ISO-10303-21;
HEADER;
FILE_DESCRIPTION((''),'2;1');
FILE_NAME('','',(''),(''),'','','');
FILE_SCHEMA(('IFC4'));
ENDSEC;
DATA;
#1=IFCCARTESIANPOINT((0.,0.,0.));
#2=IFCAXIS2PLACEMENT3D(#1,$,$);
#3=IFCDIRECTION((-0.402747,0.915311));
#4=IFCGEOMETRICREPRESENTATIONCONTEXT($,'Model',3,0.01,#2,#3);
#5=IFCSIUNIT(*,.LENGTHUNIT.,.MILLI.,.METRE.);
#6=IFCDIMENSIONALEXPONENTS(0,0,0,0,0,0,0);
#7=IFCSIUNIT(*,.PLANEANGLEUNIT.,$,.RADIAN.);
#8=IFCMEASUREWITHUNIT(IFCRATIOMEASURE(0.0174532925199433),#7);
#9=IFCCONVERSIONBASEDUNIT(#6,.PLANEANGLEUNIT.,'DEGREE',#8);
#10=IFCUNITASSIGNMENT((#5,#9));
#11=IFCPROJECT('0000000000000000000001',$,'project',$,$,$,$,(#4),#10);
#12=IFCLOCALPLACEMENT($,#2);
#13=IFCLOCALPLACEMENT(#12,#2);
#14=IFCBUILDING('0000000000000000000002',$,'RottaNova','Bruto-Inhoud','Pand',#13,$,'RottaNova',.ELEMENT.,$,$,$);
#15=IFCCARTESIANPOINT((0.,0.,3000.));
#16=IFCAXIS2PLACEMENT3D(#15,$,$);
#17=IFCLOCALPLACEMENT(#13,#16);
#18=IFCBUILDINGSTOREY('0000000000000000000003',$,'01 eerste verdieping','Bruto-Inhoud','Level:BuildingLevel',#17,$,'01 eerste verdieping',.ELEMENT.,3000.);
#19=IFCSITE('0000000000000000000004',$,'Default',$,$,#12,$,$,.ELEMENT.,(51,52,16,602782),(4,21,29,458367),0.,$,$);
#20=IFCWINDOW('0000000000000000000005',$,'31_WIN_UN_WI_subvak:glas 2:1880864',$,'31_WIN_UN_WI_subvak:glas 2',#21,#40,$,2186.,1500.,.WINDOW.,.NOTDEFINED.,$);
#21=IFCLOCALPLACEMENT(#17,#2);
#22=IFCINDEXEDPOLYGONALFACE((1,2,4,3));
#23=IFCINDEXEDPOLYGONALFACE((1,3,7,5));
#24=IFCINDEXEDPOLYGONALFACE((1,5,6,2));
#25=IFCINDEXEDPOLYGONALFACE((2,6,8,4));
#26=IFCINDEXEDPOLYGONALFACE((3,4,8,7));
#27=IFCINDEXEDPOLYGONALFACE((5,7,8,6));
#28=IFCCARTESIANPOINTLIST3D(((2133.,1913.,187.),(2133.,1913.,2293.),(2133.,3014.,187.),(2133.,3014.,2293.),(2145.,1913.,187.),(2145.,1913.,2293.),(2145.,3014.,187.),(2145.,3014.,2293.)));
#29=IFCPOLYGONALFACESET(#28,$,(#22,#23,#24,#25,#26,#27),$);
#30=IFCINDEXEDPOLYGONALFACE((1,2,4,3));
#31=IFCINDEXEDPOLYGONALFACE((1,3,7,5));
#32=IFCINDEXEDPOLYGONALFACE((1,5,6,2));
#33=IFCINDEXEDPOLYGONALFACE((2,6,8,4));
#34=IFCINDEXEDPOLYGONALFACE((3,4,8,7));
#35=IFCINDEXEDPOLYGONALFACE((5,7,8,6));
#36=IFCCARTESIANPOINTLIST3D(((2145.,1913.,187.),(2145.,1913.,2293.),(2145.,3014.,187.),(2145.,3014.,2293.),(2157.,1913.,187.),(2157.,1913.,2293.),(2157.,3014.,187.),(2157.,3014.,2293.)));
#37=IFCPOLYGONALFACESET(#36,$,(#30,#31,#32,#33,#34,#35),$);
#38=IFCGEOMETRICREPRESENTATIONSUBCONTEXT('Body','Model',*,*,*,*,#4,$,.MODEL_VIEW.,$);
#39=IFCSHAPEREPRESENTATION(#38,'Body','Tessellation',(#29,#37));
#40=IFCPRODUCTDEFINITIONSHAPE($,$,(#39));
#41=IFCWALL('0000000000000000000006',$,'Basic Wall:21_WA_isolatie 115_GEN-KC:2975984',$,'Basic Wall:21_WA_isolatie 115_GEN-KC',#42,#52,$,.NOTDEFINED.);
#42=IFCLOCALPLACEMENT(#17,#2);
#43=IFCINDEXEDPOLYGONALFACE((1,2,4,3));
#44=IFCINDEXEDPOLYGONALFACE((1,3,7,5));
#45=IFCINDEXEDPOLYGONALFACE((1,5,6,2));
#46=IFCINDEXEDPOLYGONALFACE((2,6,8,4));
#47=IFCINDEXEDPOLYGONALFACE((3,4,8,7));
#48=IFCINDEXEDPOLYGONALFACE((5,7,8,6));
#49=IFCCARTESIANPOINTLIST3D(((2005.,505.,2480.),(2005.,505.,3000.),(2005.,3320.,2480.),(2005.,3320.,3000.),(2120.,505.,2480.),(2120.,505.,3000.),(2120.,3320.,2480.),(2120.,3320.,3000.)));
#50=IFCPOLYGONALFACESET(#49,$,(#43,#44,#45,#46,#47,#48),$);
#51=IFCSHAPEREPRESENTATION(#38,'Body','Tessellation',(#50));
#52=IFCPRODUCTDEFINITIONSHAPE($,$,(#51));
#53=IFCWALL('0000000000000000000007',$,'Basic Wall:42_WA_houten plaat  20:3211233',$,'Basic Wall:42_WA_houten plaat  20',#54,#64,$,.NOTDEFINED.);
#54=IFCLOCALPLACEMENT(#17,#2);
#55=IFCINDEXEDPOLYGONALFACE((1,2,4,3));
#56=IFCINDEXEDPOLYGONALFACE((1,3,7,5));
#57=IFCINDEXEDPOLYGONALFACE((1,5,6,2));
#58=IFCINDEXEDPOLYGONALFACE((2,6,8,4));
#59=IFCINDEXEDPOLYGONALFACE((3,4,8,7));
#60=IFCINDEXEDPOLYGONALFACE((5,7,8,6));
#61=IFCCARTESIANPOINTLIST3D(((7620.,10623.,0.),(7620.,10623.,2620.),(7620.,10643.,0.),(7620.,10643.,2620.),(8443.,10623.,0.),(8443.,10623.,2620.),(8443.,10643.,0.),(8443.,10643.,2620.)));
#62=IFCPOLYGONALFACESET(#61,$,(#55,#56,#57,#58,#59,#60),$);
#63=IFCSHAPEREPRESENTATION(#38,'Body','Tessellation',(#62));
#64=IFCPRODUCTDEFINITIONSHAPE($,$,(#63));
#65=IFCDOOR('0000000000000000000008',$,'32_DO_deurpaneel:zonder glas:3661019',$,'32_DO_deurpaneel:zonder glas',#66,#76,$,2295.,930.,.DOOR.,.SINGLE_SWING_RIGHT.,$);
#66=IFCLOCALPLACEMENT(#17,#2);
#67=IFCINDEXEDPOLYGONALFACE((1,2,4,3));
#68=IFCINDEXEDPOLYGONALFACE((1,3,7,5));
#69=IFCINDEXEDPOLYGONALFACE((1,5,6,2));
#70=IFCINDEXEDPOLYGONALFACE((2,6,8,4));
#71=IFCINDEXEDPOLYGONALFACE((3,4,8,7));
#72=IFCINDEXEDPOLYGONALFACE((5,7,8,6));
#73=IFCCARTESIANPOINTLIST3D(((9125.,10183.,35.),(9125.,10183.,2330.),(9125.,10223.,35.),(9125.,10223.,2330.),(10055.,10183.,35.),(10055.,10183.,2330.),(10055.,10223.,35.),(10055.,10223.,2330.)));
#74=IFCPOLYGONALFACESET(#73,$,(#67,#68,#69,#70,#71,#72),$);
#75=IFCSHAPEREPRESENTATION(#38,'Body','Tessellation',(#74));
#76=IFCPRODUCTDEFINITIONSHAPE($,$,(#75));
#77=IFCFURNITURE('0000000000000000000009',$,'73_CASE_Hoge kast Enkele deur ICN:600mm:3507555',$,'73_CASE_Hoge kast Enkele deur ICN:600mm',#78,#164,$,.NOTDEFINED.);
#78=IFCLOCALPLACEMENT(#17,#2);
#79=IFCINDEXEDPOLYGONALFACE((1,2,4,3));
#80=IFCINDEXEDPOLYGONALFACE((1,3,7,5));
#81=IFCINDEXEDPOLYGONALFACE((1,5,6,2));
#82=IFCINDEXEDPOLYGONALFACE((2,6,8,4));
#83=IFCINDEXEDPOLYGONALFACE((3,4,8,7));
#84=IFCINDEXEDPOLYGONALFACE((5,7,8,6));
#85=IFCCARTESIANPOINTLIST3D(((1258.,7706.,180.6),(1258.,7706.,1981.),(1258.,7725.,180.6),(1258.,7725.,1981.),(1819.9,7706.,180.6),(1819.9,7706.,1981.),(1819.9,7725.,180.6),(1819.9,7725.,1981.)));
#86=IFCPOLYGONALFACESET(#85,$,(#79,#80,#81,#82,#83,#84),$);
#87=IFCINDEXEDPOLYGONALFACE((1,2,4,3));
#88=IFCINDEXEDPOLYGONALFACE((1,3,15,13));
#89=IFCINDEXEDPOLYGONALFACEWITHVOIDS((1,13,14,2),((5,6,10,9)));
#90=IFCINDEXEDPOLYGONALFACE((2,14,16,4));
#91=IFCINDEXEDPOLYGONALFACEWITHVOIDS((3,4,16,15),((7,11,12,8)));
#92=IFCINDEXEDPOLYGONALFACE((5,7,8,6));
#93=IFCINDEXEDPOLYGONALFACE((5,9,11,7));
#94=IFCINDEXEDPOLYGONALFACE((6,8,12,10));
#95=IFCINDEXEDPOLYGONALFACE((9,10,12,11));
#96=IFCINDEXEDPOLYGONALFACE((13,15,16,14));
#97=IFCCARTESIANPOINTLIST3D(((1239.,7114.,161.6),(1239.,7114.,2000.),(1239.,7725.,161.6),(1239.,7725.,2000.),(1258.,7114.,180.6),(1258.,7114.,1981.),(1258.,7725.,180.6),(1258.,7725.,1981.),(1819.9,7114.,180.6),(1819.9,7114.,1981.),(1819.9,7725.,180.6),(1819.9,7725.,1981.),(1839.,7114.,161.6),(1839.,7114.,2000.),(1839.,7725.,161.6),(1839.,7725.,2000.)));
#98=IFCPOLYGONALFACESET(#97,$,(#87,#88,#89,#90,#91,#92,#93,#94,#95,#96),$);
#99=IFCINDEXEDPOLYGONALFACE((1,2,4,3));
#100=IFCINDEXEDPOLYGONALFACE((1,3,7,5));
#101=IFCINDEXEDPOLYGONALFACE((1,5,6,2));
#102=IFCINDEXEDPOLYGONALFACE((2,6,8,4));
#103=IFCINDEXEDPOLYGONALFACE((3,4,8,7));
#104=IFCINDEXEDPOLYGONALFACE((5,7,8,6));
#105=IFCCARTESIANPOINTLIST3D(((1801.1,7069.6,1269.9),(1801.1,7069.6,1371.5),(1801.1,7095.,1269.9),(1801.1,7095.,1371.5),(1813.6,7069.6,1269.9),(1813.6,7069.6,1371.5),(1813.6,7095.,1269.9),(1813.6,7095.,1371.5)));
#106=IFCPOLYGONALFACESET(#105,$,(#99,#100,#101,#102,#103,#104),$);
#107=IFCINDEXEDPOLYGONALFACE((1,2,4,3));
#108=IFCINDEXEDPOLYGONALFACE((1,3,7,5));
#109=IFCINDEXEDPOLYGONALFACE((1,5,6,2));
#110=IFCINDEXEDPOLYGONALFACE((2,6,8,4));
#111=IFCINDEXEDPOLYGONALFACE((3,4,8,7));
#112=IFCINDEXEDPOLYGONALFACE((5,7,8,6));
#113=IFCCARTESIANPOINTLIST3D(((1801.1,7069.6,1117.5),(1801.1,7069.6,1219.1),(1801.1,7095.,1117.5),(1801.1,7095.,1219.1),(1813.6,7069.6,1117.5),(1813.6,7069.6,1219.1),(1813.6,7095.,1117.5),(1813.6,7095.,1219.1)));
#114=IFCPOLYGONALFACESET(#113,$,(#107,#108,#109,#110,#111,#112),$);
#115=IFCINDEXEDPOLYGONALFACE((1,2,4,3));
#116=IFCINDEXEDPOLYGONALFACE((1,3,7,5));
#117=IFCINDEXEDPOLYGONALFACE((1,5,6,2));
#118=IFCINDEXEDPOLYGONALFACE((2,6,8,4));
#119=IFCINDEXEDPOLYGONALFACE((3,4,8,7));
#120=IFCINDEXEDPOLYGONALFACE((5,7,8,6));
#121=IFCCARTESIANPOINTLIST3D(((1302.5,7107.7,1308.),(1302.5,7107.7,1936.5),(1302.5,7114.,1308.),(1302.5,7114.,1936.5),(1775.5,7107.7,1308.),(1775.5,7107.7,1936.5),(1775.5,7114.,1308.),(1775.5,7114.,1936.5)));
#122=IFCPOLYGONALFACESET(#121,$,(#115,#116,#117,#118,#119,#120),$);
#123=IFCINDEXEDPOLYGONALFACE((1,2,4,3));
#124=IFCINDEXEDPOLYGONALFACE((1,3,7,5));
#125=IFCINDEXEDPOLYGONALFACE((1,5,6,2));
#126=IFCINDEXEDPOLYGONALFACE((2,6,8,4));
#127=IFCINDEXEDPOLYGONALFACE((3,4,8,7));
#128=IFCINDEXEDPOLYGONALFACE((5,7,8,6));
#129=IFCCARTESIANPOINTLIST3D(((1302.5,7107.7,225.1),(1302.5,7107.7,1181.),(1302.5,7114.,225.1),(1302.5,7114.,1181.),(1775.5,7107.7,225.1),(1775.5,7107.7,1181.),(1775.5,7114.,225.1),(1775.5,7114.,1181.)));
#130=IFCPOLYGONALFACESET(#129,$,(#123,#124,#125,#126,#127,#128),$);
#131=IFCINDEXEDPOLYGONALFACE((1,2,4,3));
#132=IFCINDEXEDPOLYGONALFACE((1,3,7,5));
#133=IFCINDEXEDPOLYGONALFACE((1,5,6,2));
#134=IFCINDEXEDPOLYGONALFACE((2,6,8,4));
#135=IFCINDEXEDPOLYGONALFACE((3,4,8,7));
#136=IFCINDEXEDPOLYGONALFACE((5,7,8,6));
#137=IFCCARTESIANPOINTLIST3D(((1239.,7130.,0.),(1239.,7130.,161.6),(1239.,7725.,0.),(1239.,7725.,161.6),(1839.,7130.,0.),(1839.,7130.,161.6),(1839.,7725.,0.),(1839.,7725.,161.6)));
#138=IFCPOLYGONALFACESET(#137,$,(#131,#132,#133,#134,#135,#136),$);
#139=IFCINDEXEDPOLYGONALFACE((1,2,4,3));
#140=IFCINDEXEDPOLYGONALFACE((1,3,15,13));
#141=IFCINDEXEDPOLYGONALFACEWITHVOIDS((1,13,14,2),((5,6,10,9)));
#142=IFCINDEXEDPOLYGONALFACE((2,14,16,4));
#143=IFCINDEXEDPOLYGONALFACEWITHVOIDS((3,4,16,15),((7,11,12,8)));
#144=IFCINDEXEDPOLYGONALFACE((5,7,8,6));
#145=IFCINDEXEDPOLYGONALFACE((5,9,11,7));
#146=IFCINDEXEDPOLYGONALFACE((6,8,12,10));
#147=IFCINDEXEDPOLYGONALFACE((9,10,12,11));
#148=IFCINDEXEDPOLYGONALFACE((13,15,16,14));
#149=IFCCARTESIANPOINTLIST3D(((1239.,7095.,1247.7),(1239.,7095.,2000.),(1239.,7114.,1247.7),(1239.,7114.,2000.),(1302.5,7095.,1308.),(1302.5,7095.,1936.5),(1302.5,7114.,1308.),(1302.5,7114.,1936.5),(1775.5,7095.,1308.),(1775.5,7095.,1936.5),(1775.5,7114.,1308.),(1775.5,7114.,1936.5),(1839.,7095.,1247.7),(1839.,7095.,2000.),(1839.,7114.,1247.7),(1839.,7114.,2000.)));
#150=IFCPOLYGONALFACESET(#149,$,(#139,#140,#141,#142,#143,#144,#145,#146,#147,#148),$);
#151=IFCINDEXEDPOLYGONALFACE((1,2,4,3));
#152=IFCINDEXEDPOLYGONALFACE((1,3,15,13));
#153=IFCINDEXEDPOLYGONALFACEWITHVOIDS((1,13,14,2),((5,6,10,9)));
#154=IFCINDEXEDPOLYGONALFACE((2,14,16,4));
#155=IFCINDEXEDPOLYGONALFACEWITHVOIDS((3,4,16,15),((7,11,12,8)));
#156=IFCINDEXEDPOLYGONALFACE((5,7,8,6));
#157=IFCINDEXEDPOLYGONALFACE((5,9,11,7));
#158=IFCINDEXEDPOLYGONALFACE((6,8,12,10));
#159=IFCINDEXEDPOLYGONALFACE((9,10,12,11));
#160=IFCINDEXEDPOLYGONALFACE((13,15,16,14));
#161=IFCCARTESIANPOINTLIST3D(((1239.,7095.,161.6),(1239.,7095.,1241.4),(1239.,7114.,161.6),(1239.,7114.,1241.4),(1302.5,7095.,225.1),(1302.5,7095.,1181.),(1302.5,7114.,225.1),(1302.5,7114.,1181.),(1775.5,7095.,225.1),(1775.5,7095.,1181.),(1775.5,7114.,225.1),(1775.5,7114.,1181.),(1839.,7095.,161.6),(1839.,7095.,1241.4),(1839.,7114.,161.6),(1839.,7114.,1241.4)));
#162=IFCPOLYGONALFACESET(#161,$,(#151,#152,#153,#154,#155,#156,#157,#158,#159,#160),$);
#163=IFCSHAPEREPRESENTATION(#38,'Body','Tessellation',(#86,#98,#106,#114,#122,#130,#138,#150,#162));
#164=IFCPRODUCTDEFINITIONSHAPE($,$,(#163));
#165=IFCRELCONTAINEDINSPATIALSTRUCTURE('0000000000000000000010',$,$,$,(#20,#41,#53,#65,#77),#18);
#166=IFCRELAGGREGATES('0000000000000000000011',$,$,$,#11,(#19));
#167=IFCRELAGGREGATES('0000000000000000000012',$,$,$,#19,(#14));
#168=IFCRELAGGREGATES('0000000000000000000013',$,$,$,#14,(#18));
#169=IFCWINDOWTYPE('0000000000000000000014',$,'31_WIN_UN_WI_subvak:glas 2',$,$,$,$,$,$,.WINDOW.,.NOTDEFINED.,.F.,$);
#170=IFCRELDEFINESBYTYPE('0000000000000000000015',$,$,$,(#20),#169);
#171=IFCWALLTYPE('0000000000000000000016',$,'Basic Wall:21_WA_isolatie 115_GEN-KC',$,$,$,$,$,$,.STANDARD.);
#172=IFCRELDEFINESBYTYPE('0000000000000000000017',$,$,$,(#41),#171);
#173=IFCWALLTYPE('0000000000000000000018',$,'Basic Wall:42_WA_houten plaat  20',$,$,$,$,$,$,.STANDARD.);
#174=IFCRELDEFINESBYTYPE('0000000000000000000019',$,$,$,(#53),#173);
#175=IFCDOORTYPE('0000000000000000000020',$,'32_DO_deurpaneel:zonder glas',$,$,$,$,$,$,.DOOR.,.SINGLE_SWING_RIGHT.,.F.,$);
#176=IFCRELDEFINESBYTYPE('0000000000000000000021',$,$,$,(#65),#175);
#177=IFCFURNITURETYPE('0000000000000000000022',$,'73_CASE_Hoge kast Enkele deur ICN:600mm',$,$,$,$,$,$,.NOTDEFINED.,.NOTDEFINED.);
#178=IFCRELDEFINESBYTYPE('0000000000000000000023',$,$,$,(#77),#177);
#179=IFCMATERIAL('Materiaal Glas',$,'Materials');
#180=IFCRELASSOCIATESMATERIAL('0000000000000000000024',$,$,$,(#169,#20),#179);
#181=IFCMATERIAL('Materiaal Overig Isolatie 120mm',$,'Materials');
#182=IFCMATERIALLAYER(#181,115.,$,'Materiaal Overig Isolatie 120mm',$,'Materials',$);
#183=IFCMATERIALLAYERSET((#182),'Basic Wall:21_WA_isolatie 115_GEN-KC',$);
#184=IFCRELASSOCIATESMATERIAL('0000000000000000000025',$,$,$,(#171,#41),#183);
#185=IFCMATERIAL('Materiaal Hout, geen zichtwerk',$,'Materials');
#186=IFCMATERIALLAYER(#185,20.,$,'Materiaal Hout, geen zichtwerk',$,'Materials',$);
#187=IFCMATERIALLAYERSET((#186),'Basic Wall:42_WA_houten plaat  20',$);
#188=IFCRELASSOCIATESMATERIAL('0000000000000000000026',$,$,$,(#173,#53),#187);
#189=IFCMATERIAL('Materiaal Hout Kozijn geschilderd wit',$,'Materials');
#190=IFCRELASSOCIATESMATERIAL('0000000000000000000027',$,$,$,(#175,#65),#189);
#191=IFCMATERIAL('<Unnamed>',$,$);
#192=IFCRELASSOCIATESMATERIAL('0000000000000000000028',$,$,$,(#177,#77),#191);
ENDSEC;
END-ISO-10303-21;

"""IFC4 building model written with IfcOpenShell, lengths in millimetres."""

from ifc_helpers import new_model, entity, si_unit, converted_unit, direction, frame, frame_2d, origin, origin_2d_with_axis, place, context, subcontext, project, spatial, polyline, rectangle, outline, extrude, source, transform, mapped, material, layer, layer_set, type_object, type_shapes, element, save


model = new_model("IFC4")

# Units and contexts
model_context = context("Model", 3, precision=0.01, world=origin(), true_north=direction((-0.402747, 0.915311)))
body_context = subcontext(model_context, "Body", "Model", "MODEL_VIEW")
ifc_project = project(units=[si_unit("LENGTHUNIT", "METRE", prefix="MILLI"), converted_unit("PLANEANGLEUNIT", "DEGREE", entity("IfcRatioMeasure", 0.0174532925199433), si_unit("PLANEANGLEUNIT", "RADIAN"), dimensions=[0, 0, 0, 0, 0, 0, 0])], contexts=[model_context])

# Site, building, storey
site_placement = place(None, origin())
site = spatial("IfcSite", under=ifc_project, at=site_placement, Name="Default", CompositionType="ELEMENT", RefLatitude=(51, 52, 16, 602782), RefLongitude=(4, 21, 29, 458367), RefElevation=0.0)
building_placement = place(site_placement, origin())
building = spatial("IfcBuilding", under=site, at=building_placement, Name="RottaNova", Description="Bruto-Inhoud", ObjectType="Pand", LongName="RottaNova", CompositionType="ELEMENT")
storey_placement = place(building_placement, frame((0.0, 0.0, 3000.0)))
storey = spatial("IfcBuildingStorey", under=building, at=storey_placement, Name="01 eerste verdieping", Description="Bruto-Inhoud", ObjectType="Level:BuildingLevel", LongName="01 eerste verdieping", CompositionType="ELEMENT", Elevation=3000.0)

# Shared definitions
ifc_material_1 = material(Name="Materiaal Glas", Category="Materials")

# Window
window_type = type_object("IfcWindowType", Name="31_WIN_UN_WI_subvak:glas 2", ParameterTakesPrecedence=False, PartitioningType="NOTDEFINED", PredefinedType="WINDOW", material=ifc_material_1)
shared_shape_1 = source(origin(), body_context, "Body", "SweptSolid", [
    extrude(rectangle(XDim=12.0, YDim=1101.0, at=frame_2d((0.0, 0.0), x_axis=(1.0, 0.0))), frame((0.0, 6.0, 0.0), z_axis=(0.0, 0.0, 1.0), x_axis=(0.0, -1.0, 0.0)), (0.0, 0.0, 1.0), 2106.0),
    extrude(rectangle(XDim=12.0, YDim=1101.0, at=origin_2d_with_axis()), frame((0.0, -6.0, 0.0), z_axis=(0.0, 0.0, 1.0), x_axis=(0.0, -1.0, 0.0)), (0.0, 0.0, 1.0), 2106.0),
])
type_shapes(window_type, [shared_shape_1])
window_placement = place(storey_placement, frame((2145.0, 2463.5, 187.0), z_axis=(0.0, 0.0, 1.0), x_axis=(0.0, 1.0, 0.0)))
element("IfcWindow", 1, at=window_placement, inside=storey, type_object=window_type, material=ifc_material_1, Name="31_WIN_UN_WI_subvak:glas 2:1880864", ObjectType="31_WIN_UN_WI_subvak:glas 2", OverallHeight=2186.0, OverallWidth=1500.0, PartitioningType="NOTDEFINED", PredefinedType="WINDOW", context=body_context, shape_type="MappedRepresentation", body=[
    mapped(shared_shape_1, transform((0.0, 0.0, 0.0), scale=1.0)),
])

# Walls
ifc_material_2 = material(Name="Materiaal Overig Isolatie 120mm", Category="Materials")
ifc_layer_1 = layer(ifc_material_2, 115.0, Name="Materiaal Overig Isolatie 120mm", Category="Materials")
ifc_layer_set_1 = layer_set([ifc_layer_1], Name="Basic Wall:21_WA_isolatie 115_GEN-KC")
wall_type_1 = type_object("IfcWallType", Name="Basic Wall:21_WA_isolatie 115_GEN-KC", PredefinedType="STANDARD", material=ifc_layer_set_1)
wall_1_placement = place(storey_placement, frame((2062.5, 3320.0, 2480.0), z_axis=(0.0, 0.0, 1.0), x_axis=(0.0, -1.0, 0.0)))
element("IfcWall", 2, at=wall_1_placement, inside=storey, type_object=wall_type_1, material=ifc_layer_set_1, Name="Basic Wall:21_WA_isolatie 115_GEN-KC:2975984", ObjectType="Basic Wall:21_WA_isolatie 115_GEN-KC", PredefinedType="NOTDEFINED", context=body_context, shape_type="SweptSolid", body=[
    extrude(rectangle(XDim=2815.0, YDim=115.0, at=frame_2d((1407.5, 0.0), x_axis=(-1.0, 0.0))), origin(), (0.0, 0.0, 1.0), 520.0),
])
ifc_material_3 = material(Name="Materiaal Hout, geen zichtwerk", Category="Materials")
ifc_layer_2 = layer(ifc_material_3, 20.0, Name="Materiaal Hout, geen zichtwerk", Category="Materials")
ifc_layer_set_2 = layer_set([ifc_layer_2], Name="Basic Wall:42_WA_houten plaat  20")
wall_type_2 = type_object("IfcWallType", Name="Basic Wall:42_WA_houten plaat  20", PredefinedType="STANDARD", material=ifc_layer_set_2)
wall_2_placement = place(storey_placement, frame((7620.0, 10633.0, 0.0)))
element("IfcWall", 3, at=wall_2_placement, inside=storey, type_object=wall_type_2, material=ifc_layer_set_2, Name="Basic Wall:42_WA_houten plaat  20:3211233", ObjectType="Basic Wall:42_WA_houten plaat  20", PredefinedType="NOTDEFINED", context=body_context, shape_type="SweptSolid", body=[
    extrude(rectangle(XDim=823.0, YDim=20.0, at=frame_2d((411.5, 0.0), x_axis=(-1.0, 0.0))), origin(), (0.0, 0.0, 1.0), 2620.0),
])

# Door
ifc_material_4 = material(Name="Materiaal Hout Kozijn geschilderd wit", Category="Materials")
door_type = type_object("IfcDoorType", Name="32_DO_deurpaneel:zonder glas", OperationType="SINGLE_SWING_RIGHT", ParameterTakesPrecedence=False, PredefinedType="DOOR", material=ifc_material_4)
shared_shape_2 = source(origin(), body_context, "Body", "SweptSolid", [
    extrude(rectangle(XDim=2295.0, YDim=40.0, at=frame_2d((0.0, 0.0), x_axis=(0.0, 1.0))), frame((-465.0, -20.0, 1182.5), z_axis=(1.0, 0.0, 0.0), x_axis=(0.0, 1.0, 0.0)), (0.0, 0.0, 1.0), 930.0),
])
type_shapes(door_type, [shared_shape_2])
door_placement = place(storey_placement, frame((9590.0, 10223.0, 0.0)))
element("IfcDoor", 4, at=door_placement, inside=storey, type_object=door_type, material=ifc_material_4, Name="32_DO_deurpaneel:zonder glas:3661019", ObjectType="32_DO_deurpaneel:zonder glas", OperationType="SINGLE_SWING_RIGHT", OverallHeight=2295.0, OverallWidth=930.0, PredefinedType="DOOR", context=body_context, shape_type="MappedRepresentation", body=[
    mapped(shared_shape_2, transform((0.0, 0.0, 0.0), scale=1.0)),
])

# Furniture
ifc_material_5 = material(Name="<Unnamed>")
furniture_type = type_object("IfcFurnitureType", Name="73_CASE_Hoge kast Enkele deur ICN:600mm", AssemblyPlace="NOTDEFINED", PredefinedType="NOTDEFINED", material=ifc_material_5)
shared_shape_3 = source(origin(), body_context, "Body", "SweptSolid", [
    extrude(rectangle(XDim=19.1, YDim=561.9, at=origin_2d_with_axis()), frame((18.7, -9.5, 180.6), z_axis=(0.0, 0.0, 1.0), x_axis=(0.0, 1.0, 0.0)), (0.0, 0.0, 1.0), 1800.3),
    extrude(outline(polyline([(-300.0, -919.2), (300.0, -919.2), (300.0, 919.2), (-300.0, 919.2), (-300.0, -919.2)]), holes=[polyline([(-280.9, 900.2), (281.0, 900.2), (281.0, -900.2), (-280.9, -900.2), (-280.9, 900.2)])]), frame((18.7, -611.0, 1080.8), z_axis=(0.0, 1.0, 0.0), x_axis=(-1.0, 0.0, 0.0)), (0.0, 0.0, 1.0), 610.9),
    extrude(rectangle(XDim=25.4, YDim=12.5, at=frame_2d((0.0, 0.0), x_axis=(1.0, 0.0))), frame((287.1, -642.7, 1269.9), z_axis=(0.0, 0.0, 1.0), x_axis=(0.0, 1.0, 0.0)), (0.0, 0.0, 1.0), 101.6),
    extrude(rectangle(XDim=25.4, YDim=12.5, at=frame_2d((0.0, 0.0), x_axis=(1.0, 0.0))), frame((287.1, -642.7, 1117.5), z_axis=(0.0, 0.0, 1.0), x_axis=(0.0, 1.0, 0.0)), (0.0, 0.0, 1.0), 101.6),
    extrude(rectangle(XDim=6.4, YDim=473.0, at=frame_2d((0.0, 0.0), x_axis=(1.0, 0.0))), frame((18.7, -614.1, 1308.0), z_axis=(0.0, 0.0, 1.0), x_axis=(0.0, 1.0, 0.0)), (0.0, 0.0, 1.0), 628.5),
    extrude(rectangle(XDim=6.4, YDim=473.0, at=origin_2d_with_axis()), frame((18.7, -614.1, 225.1), z_axis=(0.0, 0.0, 1.0), x_axis=(0.0, 1.0, 0.0)), (0.0, 0.0, 1.0), 956.0),
    extrude(rectangle(XDim=600.0, YDim=595.0, at=frame_2d((0.0, 0.0), x_axis=(1.0, 0.0))), frame((18.7, -297.5, 0.0), z_axis=(0.0, 0.0, 1.0), x_axis=(-1.0, 0.0, 0.0)), (0.0, 0.0, 1.0), 161.6),
    extrude(outline(polyline([(-376.1, -300.0), (376.1, -300.0), (376.1, 300.0), (-376.1, 300.0), (-376.1, -300.0)]), holes=[polyline([(-312.6, -236.5), (-312.6, 236.5), (315.8, 236.5), (315.8, -236.5), (-312.6, -236.5)])]), frame((18.7, -630.0, 1623.9), z_axis=(0.0, 1.0, 0.0), x_axis=(0.0, 0.0, -1.0)), (0.0, 0.0, 1.0), 19.1),
    extrude(outline(polyline([(-300.0, -539.9), (300.0, -539.9), (300.0, 539.9), (-300.0, 539.9), (-300.0, -539.9)]), holes=[polyline([(-236.5, 479.6), (236.5, 479.6), (236.5, -476.4), (-236.5, -476.4), (-236.5, 479.6)])]), frame((18.7, -630.0, 701.5), z_axis=(0.0, 1.0, 0.0), x_axis=(-1.0, 0.0, 0.0)), (0.0, 0.0, 1.0), 19.1),
])
type_shapes(furniture_type, [shared_shape_3])
for number, where, name in (
    (5, (1520.3, 7725.0, 0.0), "73_CASE_Hoge kast Enkele deur ICN:600mm:3507555"),
):
    element("IfcFurniture", number, at=place(storey_placement, frame(where)), inside=storey, type_object=furniture_type, material=ifc_material_5, Name=name, ObjectType="73_CASE_Hoge kast Enkele deur ICN:600mm", PredefinedType="NOTDEFINED", context=body_context, shape_type="MappedRepresentation", body=[
        mapped(shared_shape_3, transform((0.0, 0.0, 0.0), scale=1.0)),
    ])

save(model, "model.ifc")
